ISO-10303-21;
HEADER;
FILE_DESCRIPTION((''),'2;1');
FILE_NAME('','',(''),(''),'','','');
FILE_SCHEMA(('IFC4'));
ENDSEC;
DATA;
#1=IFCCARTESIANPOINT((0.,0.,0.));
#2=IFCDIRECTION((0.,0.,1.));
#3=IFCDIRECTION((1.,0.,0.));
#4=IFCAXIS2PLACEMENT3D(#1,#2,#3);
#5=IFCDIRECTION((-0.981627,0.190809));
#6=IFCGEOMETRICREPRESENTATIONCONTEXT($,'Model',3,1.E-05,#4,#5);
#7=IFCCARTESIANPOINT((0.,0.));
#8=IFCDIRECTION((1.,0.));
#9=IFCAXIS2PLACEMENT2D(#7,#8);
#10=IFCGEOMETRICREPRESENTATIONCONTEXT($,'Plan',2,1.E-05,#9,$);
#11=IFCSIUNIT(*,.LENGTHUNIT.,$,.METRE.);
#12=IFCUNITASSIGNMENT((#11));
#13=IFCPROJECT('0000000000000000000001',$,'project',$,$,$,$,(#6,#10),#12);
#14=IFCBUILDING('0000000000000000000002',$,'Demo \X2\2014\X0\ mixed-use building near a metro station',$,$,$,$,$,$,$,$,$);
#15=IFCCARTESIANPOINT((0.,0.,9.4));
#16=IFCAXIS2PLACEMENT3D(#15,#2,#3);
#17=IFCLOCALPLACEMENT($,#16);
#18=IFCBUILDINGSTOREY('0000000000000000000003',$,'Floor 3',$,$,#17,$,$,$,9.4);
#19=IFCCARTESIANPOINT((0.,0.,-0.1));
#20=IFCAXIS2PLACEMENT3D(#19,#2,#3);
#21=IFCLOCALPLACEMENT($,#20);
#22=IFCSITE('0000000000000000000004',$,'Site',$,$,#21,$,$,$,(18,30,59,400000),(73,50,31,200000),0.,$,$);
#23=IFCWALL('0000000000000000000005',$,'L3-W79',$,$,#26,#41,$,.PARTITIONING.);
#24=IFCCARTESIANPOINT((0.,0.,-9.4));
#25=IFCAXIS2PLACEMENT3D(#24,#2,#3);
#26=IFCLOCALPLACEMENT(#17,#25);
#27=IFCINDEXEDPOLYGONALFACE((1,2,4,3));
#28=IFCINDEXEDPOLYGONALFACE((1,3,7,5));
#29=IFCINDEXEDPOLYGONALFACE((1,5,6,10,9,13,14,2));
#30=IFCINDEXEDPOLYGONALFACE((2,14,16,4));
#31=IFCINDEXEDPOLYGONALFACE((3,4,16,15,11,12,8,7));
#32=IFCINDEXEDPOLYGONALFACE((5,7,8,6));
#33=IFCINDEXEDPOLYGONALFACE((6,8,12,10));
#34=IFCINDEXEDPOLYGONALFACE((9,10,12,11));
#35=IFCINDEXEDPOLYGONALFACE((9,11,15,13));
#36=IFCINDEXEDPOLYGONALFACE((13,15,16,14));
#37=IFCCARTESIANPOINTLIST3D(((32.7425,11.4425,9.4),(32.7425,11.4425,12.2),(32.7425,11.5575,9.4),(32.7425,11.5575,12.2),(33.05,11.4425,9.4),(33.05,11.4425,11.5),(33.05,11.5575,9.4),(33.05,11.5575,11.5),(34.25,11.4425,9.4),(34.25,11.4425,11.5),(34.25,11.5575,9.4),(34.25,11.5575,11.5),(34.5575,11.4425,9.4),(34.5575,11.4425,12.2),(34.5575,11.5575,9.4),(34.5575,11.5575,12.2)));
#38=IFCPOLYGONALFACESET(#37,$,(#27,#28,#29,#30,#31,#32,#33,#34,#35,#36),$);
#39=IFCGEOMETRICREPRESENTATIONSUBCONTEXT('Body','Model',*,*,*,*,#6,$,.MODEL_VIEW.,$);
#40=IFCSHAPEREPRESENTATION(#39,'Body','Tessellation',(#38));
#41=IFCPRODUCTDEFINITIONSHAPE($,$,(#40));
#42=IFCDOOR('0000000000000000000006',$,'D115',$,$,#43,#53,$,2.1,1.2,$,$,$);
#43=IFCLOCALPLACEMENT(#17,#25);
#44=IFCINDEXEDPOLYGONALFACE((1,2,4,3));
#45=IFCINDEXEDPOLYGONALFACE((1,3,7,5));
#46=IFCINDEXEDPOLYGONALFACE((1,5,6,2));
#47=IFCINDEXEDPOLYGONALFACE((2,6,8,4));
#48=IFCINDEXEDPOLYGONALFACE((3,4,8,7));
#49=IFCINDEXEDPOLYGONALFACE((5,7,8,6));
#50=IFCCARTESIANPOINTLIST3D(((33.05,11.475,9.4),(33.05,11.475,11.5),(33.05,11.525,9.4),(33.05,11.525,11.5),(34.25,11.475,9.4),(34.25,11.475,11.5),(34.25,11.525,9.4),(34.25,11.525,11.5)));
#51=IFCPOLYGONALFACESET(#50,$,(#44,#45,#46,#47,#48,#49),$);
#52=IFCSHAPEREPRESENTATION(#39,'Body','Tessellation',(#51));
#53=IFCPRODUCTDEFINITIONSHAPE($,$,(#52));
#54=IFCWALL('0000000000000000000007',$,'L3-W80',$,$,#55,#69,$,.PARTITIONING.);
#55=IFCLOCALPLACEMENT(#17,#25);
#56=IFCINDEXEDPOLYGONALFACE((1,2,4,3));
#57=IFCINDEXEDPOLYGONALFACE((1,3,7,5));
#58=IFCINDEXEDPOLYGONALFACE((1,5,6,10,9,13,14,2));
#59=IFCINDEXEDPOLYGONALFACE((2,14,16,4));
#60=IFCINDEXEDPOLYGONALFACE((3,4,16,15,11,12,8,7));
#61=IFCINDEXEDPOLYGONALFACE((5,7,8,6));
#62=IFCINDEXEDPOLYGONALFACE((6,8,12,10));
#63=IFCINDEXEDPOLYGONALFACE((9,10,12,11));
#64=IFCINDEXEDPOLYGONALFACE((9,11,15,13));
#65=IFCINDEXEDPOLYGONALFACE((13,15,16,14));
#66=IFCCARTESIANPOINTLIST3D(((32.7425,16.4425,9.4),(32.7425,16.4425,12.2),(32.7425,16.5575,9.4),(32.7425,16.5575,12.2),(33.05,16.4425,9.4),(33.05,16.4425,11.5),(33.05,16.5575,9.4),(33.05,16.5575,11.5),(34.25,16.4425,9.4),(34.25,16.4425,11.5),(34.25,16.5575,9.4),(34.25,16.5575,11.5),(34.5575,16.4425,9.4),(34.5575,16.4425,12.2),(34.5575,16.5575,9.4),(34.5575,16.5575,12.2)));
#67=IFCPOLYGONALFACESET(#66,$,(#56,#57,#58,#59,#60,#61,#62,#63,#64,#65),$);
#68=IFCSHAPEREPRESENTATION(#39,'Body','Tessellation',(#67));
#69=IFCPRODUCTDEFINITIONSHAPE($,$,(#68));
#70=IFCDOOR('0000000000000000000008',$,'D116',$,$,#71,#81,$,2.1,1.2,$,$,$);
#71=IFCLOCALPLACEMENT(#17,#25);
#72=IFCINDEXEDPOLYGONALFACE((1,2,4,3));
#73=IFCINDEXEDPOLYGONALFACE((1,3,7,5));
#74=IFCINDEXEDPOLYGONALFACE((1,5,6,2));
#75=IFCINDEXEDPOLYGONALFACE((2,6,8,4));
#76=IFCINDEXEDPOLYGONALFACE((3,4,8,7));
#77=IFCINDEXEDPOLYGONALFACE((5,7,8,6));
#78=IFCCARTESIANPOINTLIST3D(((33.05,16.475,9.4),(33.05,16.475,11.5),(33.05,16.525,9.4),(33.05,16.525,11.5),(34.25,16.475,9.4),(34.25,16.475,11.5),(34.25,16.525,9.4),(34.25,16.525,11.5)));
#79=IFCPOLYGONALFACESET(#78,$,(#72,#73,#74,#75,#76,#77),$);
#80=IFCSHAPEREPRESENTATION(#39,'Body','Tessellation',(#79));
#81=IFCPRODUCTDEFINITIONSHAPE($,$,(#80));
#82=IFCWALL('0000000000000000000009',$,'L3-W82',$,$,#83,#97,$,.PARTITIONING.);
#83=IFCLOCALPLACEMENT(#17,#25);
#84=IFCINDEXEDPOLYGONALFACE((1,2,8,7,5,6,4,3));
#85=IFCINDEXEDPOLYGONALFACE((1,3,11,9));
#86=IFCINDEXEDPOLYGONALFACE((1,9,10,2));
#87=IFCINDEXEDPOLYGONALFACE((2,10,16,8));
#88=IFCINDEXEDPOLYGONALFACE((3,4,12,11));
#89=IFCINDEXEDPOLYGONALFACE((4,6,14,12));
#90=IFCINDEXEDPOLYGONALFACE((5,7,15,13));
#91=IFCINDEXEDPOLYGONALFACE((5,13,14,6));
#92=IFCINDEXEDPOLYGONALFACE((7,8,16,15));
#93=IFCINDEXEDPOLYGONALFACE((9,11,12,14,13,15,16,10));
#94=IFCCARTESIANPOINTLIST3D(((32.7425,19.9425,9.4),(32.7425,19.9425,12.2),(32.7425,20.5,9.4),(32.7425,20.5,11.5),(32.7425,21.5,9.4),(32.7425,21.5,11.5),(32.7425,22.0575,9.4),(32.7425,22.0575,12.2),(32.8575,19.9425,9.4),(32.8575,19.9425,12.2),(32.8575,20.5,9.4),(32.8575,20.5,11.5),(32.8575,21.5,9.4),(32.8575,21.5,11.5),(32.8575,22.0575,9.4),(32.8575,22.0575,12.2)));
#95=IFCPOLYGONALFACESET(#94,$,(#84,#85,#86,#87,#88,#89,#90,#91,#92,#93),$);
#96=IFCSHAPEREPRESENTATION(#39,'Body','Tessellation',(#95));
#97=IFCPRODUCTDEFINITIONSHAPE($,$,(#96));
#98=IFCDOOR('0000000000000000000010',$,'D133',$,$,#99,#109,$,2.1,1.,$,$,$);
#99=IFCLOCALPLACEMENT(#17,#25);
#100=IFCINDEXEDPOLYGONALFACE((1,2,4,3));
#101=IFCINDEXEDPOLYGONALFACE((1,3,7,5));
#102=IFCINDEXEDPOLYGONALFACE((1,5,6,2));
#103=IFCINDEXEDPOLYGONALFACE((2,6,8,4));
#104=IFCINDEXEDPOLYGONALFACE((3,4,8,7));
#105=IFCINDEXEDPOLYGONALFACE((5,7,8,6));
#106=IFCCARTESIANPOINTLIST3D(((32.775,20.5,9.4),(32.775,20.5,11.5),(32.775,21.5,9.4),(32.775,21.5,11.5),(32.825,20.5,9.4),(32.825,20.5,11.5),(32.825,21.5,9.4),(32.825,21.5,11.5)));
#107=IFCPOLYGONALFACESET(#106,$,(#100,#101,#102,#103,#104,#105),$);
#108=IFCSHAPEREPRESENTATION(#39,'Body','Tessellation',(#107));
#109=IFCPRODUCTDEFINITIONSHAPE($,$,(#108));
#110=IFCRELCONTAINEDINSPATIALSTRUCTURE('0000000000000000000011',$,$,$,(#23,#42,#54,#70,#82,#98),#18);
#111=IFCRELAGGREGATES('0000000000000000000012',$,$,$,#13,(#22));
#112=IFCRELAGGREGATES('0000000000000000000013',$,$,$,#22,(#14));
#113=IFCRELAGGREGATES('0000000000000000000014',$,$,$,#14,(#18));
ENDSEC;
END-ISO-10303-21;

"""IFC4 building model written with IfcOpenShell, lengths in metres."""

from ifc_helpers import new_model, si_unit, direction, frame, origin_with_axes, origin_2d_with_axis, place, context, subcontext, project, spatial, line, indexed_curve, outline, extrude, element, fill, save


model = new_model("IFC4")

# Units and contexts
model_context = context("Model", 3, precision=1e-05, world=origin_with_axes(), true_north=direction((-0.981627, 0.190809)))
plan_context = context("Plan", 2, precision=1e-05, world=origin_2d_with_axis())
body_context = subcontext(model_context, "Body", "Model", "MODEL_VIEW")
ifc_project = project(units=[si_unit("LENGTHUNIT", "METRE")], contexts=[model_context, plan_context])

# Site, building, storey
site_placement = place(None, frame((0.0, 0.0, -0.1), z_axis=(0.0, 0.0, 1.0), x_axis=(1.0, 0.0, 0.0)))
site = spatial("IfcSite", under=ifc_project, at=site_placement, Name="Site", RefLatitude=(18, 30, 59, 400000), RefLongitude=(73, 50, 31, 200000), RefElevation=0.0)
building = spatial("IfcBuilding", under=site, Name="Demo — mixed-use building near a metro station")
storey_placement = place(None, frame((0.0, 0.0, 9.4), z_axis=(0.0, 0.0, 1.0), x_axis=(1.0, 0.0, 0.0)))
storey = spatial("IfcBuildingStorey", under=building, at=storey_placement, Name="Floor 3", Elevation=9.4)

# Walls, openings, doors
wall_1_placement = place(storey_placement, frame((0.0, 0.0, -9.4), z_axis=(0.0, 0.0, 1.0), x_axis=(1.0, 0.0, 0.0)))
wall_1 = element("IfcWall", 1, at=wall_1_placement, inside=storey, Name="L3-W79", PredefinedType="PARTITIONING", context=body_context, shape_type="SweptSolid", body=[
    extrude(outline(indexed_curve([(34.5575, 11.4425), (32.7425, 11.4425), (32.7425, 11.5575), (34.5575, 11.5575)], segments=[line(1, 2, 3, 4, 1)])), frame((0.0, 0.0, 9.4), z_axis=(0.0, 0.0, 1.0), x_axis=(1.0, 0.0, 0.0)), (0.0, 0.0, 1.0), 2.8),
])
opening_1_placement = place(wall_1_placement, origin_with_axes())
opening_1 = element("IfcOpeningElement", 2, at=opening_1_placement, cuts=wall_1, context=body_context, shape_type="SweptSolid", body=[
    extrude(outline(indexed_curve([(34.25, 11.3925), (33.05, 11.3925), (33.05, 11.6075), (34.25, 11.6075)], segments=[line(1, 2, 3, 4, 1)])), frame((0.0, 0.0, 9.4), z_axis=(0.0, 0.0, 1.0), x_axis=(1.0, 0.0, 0.0)), (0.0, 0.0, 1.0), 2.1),
])
door_1_placement = place(storey_placement, frame((0.0, 0.0, -9.4), z_axis=(0.0, 0.0, 1.0), x_axis=(1.0, 0.0, 0.0)))
door_1 = element("IfcDoor", 3, at=door_1_placement, inside=storey, Name="D115", OverallHeight=2.1, OverallWidth=1.2, context=body_context, shape_type="SweptSolid", body=[
    extrude(outline(indexed_curve([(34.25, 11.475), (33.05, 11.475), (33.05, 11.525), (34.25, 11.525)], segments=[line(1, 2, 3, 4, 1)])), frame((0.0, 0.0, 9.4), z_axis=(0.0, 0.0, 1.0), x_axis=(1.0, 0.0, 0.0)), (0.0, 0.0, 1.0), 2.1),
])
fill(opening_1, door_1)
wall_2_placement = place(storey_placement, frame((0.0, 0.0, -9.4), z_axis=(0.0, 0.0, 1.0), x_axis=(1.0, 0.0, 0.0)))
wall_2 = element("IfcWall", 4, at=wall_2_placement, inside=storey, Name="L3-W80", PredefinedType="PARTITIONING", context=body_context, shape_type="SweptSolid", body=[
    extrude(outline(indexed_curve([(34.5575, 16.4425), (32.7425, 16.4425), (32.7425, 16.5575), (34.5575, 16.5575)], segments=[line(1, 2, 3, 4, 1)])), frame((0.0, 0.0, 9.4), z_axis=(0.0, 0.0, 1.0), x_axis=(1.0, 0.0, 0.0)), (0.0, 0.0, 1.0), 2.8),
])
opening_2_placement = place(wall_2_placement, origin_with_axes())
opening_2 = element("IfcOpeningElement", 5, at=opening_2_placement, cuts=wall_2, context=body_context, shape_type="SweptSolid", body=[
    extrude(outline(indexed_curve([(34.25, 16.3925), (33.05, 16.3925), (33.05, 16.6075), (34.25, 16.6075)], segments=[line(1, 2, 3, 4, 1)])), frame((0.0, 0.0, 9.4), z_axis=(0.0, 0.0, 1.0), x_axis=(1.0, 0.0, 0.0)), (0.0, 0.0, 1.0), 2.1),
])
door_2_placement = place(storey_placement, frame((0.0, 0.0, -9.4), z_axis=(0.0, 0.0, 1.0), x_axis=(1.0, 0.0, 0.0)))
door_2 = element("IfcDoor", 6, at=door_2_placement, inside=storey, Name="D116", OverallHeight=2.1, OverallWidth=1.2, context=body_context, shape_type="SweptSolid", body=[
    extrude(outline(indexed_curve([(34.25, 16.475), (33.05, 16.475), (33.05, 16.525), (34.25, 16.525)], segments=[line(1, 2, 3, 4, 1)])), frame((0.0, 0.0, 9.4), z_axis=(0.0, 0.0, 1.0), x_axis=(1.0, 0.0, 0.0)), (0.0, 0.0, 1.0), 2.1),
])
fill(opening_2, door_2)

# Wall, opening, door
wall_3_placement = place(storey_placement, frame((0.0, 0.0, -9.4), z_axis=(0.0, 0.0, 1.0), x_axis=(1.0, 0.0, 0.0)))
wall_3 = element("IfcWall", 7, at=wall_3_placement, inside=storey, Name="L3-W82", PredefinedType="PARTITIONING", context=body_context, shape_type="SweptSolid", body=[
    extrude(outline(indexed_curve([(32.8575, 22.0575), (32.8575, 19.9425), (32.7425, 19.9425), (32.7425, 22.0575)], segments=[line(1, 2, 3, 4, 1)])), frame((0.0, 0.0, 9.4), z_axis=(0.0, 0.0, 1.0), x_axis=(1.0, 0.0, 0.0)), (0.0, 0.0, 1.0), 2.8),
])
opening_3_placement = place(wall_3_placement, origin_with_axes())
opening_3 = element("IfcOpeningElement", 8, at=opening_3_placement, cuts=wall_3, context=body_context, shape_type="SweptSolid", body=[
    extrude(outline(indexed_curve([(32.9075, 21.5), (32.9075, 20.5), (32.6925, 20.5), (32.6925, 21.5)], segments=[line(1, 2, 3, 4, 1)])), frame((0.0, 0.0, 9.4), z_axis=(0.0, 0.0, 1.0), x_axis=(1.0, 0.0, 0.0)), (0.0, 0.0, 1.0), 2.1),
])
door_3_placement = place(storey_placement, frame((0.0, 0.0, -9.4), z_axis=(0.0, 0.0, 1.0), x_axis=(1.0, 0.0, 0.0)))
door_3 = element("IfcDoor", 9, at=door_3_placement, inside=storey, Name="D133", OverallHeight=2.1, OverallWidth=1.0, context=body_context, shape_type="SweptSolid", body=[
    extrude(outline(indexed_curve([(32.825, 21.5), (32.825, 20.5), (32.775, 20.5), (32.775, 21.5)], segments=[line(1, 2, 3, 4, 1)])), frame((0.0, 0.0, 9.4), z_axis=(0.0, 0.0, 1.0), x_axis=(1.0, 0.0, 0.0)), (0.0, 0.0, 1.0), 2.1),
])
fill(opening_3, door_3)

save(model, "model.ifc")
